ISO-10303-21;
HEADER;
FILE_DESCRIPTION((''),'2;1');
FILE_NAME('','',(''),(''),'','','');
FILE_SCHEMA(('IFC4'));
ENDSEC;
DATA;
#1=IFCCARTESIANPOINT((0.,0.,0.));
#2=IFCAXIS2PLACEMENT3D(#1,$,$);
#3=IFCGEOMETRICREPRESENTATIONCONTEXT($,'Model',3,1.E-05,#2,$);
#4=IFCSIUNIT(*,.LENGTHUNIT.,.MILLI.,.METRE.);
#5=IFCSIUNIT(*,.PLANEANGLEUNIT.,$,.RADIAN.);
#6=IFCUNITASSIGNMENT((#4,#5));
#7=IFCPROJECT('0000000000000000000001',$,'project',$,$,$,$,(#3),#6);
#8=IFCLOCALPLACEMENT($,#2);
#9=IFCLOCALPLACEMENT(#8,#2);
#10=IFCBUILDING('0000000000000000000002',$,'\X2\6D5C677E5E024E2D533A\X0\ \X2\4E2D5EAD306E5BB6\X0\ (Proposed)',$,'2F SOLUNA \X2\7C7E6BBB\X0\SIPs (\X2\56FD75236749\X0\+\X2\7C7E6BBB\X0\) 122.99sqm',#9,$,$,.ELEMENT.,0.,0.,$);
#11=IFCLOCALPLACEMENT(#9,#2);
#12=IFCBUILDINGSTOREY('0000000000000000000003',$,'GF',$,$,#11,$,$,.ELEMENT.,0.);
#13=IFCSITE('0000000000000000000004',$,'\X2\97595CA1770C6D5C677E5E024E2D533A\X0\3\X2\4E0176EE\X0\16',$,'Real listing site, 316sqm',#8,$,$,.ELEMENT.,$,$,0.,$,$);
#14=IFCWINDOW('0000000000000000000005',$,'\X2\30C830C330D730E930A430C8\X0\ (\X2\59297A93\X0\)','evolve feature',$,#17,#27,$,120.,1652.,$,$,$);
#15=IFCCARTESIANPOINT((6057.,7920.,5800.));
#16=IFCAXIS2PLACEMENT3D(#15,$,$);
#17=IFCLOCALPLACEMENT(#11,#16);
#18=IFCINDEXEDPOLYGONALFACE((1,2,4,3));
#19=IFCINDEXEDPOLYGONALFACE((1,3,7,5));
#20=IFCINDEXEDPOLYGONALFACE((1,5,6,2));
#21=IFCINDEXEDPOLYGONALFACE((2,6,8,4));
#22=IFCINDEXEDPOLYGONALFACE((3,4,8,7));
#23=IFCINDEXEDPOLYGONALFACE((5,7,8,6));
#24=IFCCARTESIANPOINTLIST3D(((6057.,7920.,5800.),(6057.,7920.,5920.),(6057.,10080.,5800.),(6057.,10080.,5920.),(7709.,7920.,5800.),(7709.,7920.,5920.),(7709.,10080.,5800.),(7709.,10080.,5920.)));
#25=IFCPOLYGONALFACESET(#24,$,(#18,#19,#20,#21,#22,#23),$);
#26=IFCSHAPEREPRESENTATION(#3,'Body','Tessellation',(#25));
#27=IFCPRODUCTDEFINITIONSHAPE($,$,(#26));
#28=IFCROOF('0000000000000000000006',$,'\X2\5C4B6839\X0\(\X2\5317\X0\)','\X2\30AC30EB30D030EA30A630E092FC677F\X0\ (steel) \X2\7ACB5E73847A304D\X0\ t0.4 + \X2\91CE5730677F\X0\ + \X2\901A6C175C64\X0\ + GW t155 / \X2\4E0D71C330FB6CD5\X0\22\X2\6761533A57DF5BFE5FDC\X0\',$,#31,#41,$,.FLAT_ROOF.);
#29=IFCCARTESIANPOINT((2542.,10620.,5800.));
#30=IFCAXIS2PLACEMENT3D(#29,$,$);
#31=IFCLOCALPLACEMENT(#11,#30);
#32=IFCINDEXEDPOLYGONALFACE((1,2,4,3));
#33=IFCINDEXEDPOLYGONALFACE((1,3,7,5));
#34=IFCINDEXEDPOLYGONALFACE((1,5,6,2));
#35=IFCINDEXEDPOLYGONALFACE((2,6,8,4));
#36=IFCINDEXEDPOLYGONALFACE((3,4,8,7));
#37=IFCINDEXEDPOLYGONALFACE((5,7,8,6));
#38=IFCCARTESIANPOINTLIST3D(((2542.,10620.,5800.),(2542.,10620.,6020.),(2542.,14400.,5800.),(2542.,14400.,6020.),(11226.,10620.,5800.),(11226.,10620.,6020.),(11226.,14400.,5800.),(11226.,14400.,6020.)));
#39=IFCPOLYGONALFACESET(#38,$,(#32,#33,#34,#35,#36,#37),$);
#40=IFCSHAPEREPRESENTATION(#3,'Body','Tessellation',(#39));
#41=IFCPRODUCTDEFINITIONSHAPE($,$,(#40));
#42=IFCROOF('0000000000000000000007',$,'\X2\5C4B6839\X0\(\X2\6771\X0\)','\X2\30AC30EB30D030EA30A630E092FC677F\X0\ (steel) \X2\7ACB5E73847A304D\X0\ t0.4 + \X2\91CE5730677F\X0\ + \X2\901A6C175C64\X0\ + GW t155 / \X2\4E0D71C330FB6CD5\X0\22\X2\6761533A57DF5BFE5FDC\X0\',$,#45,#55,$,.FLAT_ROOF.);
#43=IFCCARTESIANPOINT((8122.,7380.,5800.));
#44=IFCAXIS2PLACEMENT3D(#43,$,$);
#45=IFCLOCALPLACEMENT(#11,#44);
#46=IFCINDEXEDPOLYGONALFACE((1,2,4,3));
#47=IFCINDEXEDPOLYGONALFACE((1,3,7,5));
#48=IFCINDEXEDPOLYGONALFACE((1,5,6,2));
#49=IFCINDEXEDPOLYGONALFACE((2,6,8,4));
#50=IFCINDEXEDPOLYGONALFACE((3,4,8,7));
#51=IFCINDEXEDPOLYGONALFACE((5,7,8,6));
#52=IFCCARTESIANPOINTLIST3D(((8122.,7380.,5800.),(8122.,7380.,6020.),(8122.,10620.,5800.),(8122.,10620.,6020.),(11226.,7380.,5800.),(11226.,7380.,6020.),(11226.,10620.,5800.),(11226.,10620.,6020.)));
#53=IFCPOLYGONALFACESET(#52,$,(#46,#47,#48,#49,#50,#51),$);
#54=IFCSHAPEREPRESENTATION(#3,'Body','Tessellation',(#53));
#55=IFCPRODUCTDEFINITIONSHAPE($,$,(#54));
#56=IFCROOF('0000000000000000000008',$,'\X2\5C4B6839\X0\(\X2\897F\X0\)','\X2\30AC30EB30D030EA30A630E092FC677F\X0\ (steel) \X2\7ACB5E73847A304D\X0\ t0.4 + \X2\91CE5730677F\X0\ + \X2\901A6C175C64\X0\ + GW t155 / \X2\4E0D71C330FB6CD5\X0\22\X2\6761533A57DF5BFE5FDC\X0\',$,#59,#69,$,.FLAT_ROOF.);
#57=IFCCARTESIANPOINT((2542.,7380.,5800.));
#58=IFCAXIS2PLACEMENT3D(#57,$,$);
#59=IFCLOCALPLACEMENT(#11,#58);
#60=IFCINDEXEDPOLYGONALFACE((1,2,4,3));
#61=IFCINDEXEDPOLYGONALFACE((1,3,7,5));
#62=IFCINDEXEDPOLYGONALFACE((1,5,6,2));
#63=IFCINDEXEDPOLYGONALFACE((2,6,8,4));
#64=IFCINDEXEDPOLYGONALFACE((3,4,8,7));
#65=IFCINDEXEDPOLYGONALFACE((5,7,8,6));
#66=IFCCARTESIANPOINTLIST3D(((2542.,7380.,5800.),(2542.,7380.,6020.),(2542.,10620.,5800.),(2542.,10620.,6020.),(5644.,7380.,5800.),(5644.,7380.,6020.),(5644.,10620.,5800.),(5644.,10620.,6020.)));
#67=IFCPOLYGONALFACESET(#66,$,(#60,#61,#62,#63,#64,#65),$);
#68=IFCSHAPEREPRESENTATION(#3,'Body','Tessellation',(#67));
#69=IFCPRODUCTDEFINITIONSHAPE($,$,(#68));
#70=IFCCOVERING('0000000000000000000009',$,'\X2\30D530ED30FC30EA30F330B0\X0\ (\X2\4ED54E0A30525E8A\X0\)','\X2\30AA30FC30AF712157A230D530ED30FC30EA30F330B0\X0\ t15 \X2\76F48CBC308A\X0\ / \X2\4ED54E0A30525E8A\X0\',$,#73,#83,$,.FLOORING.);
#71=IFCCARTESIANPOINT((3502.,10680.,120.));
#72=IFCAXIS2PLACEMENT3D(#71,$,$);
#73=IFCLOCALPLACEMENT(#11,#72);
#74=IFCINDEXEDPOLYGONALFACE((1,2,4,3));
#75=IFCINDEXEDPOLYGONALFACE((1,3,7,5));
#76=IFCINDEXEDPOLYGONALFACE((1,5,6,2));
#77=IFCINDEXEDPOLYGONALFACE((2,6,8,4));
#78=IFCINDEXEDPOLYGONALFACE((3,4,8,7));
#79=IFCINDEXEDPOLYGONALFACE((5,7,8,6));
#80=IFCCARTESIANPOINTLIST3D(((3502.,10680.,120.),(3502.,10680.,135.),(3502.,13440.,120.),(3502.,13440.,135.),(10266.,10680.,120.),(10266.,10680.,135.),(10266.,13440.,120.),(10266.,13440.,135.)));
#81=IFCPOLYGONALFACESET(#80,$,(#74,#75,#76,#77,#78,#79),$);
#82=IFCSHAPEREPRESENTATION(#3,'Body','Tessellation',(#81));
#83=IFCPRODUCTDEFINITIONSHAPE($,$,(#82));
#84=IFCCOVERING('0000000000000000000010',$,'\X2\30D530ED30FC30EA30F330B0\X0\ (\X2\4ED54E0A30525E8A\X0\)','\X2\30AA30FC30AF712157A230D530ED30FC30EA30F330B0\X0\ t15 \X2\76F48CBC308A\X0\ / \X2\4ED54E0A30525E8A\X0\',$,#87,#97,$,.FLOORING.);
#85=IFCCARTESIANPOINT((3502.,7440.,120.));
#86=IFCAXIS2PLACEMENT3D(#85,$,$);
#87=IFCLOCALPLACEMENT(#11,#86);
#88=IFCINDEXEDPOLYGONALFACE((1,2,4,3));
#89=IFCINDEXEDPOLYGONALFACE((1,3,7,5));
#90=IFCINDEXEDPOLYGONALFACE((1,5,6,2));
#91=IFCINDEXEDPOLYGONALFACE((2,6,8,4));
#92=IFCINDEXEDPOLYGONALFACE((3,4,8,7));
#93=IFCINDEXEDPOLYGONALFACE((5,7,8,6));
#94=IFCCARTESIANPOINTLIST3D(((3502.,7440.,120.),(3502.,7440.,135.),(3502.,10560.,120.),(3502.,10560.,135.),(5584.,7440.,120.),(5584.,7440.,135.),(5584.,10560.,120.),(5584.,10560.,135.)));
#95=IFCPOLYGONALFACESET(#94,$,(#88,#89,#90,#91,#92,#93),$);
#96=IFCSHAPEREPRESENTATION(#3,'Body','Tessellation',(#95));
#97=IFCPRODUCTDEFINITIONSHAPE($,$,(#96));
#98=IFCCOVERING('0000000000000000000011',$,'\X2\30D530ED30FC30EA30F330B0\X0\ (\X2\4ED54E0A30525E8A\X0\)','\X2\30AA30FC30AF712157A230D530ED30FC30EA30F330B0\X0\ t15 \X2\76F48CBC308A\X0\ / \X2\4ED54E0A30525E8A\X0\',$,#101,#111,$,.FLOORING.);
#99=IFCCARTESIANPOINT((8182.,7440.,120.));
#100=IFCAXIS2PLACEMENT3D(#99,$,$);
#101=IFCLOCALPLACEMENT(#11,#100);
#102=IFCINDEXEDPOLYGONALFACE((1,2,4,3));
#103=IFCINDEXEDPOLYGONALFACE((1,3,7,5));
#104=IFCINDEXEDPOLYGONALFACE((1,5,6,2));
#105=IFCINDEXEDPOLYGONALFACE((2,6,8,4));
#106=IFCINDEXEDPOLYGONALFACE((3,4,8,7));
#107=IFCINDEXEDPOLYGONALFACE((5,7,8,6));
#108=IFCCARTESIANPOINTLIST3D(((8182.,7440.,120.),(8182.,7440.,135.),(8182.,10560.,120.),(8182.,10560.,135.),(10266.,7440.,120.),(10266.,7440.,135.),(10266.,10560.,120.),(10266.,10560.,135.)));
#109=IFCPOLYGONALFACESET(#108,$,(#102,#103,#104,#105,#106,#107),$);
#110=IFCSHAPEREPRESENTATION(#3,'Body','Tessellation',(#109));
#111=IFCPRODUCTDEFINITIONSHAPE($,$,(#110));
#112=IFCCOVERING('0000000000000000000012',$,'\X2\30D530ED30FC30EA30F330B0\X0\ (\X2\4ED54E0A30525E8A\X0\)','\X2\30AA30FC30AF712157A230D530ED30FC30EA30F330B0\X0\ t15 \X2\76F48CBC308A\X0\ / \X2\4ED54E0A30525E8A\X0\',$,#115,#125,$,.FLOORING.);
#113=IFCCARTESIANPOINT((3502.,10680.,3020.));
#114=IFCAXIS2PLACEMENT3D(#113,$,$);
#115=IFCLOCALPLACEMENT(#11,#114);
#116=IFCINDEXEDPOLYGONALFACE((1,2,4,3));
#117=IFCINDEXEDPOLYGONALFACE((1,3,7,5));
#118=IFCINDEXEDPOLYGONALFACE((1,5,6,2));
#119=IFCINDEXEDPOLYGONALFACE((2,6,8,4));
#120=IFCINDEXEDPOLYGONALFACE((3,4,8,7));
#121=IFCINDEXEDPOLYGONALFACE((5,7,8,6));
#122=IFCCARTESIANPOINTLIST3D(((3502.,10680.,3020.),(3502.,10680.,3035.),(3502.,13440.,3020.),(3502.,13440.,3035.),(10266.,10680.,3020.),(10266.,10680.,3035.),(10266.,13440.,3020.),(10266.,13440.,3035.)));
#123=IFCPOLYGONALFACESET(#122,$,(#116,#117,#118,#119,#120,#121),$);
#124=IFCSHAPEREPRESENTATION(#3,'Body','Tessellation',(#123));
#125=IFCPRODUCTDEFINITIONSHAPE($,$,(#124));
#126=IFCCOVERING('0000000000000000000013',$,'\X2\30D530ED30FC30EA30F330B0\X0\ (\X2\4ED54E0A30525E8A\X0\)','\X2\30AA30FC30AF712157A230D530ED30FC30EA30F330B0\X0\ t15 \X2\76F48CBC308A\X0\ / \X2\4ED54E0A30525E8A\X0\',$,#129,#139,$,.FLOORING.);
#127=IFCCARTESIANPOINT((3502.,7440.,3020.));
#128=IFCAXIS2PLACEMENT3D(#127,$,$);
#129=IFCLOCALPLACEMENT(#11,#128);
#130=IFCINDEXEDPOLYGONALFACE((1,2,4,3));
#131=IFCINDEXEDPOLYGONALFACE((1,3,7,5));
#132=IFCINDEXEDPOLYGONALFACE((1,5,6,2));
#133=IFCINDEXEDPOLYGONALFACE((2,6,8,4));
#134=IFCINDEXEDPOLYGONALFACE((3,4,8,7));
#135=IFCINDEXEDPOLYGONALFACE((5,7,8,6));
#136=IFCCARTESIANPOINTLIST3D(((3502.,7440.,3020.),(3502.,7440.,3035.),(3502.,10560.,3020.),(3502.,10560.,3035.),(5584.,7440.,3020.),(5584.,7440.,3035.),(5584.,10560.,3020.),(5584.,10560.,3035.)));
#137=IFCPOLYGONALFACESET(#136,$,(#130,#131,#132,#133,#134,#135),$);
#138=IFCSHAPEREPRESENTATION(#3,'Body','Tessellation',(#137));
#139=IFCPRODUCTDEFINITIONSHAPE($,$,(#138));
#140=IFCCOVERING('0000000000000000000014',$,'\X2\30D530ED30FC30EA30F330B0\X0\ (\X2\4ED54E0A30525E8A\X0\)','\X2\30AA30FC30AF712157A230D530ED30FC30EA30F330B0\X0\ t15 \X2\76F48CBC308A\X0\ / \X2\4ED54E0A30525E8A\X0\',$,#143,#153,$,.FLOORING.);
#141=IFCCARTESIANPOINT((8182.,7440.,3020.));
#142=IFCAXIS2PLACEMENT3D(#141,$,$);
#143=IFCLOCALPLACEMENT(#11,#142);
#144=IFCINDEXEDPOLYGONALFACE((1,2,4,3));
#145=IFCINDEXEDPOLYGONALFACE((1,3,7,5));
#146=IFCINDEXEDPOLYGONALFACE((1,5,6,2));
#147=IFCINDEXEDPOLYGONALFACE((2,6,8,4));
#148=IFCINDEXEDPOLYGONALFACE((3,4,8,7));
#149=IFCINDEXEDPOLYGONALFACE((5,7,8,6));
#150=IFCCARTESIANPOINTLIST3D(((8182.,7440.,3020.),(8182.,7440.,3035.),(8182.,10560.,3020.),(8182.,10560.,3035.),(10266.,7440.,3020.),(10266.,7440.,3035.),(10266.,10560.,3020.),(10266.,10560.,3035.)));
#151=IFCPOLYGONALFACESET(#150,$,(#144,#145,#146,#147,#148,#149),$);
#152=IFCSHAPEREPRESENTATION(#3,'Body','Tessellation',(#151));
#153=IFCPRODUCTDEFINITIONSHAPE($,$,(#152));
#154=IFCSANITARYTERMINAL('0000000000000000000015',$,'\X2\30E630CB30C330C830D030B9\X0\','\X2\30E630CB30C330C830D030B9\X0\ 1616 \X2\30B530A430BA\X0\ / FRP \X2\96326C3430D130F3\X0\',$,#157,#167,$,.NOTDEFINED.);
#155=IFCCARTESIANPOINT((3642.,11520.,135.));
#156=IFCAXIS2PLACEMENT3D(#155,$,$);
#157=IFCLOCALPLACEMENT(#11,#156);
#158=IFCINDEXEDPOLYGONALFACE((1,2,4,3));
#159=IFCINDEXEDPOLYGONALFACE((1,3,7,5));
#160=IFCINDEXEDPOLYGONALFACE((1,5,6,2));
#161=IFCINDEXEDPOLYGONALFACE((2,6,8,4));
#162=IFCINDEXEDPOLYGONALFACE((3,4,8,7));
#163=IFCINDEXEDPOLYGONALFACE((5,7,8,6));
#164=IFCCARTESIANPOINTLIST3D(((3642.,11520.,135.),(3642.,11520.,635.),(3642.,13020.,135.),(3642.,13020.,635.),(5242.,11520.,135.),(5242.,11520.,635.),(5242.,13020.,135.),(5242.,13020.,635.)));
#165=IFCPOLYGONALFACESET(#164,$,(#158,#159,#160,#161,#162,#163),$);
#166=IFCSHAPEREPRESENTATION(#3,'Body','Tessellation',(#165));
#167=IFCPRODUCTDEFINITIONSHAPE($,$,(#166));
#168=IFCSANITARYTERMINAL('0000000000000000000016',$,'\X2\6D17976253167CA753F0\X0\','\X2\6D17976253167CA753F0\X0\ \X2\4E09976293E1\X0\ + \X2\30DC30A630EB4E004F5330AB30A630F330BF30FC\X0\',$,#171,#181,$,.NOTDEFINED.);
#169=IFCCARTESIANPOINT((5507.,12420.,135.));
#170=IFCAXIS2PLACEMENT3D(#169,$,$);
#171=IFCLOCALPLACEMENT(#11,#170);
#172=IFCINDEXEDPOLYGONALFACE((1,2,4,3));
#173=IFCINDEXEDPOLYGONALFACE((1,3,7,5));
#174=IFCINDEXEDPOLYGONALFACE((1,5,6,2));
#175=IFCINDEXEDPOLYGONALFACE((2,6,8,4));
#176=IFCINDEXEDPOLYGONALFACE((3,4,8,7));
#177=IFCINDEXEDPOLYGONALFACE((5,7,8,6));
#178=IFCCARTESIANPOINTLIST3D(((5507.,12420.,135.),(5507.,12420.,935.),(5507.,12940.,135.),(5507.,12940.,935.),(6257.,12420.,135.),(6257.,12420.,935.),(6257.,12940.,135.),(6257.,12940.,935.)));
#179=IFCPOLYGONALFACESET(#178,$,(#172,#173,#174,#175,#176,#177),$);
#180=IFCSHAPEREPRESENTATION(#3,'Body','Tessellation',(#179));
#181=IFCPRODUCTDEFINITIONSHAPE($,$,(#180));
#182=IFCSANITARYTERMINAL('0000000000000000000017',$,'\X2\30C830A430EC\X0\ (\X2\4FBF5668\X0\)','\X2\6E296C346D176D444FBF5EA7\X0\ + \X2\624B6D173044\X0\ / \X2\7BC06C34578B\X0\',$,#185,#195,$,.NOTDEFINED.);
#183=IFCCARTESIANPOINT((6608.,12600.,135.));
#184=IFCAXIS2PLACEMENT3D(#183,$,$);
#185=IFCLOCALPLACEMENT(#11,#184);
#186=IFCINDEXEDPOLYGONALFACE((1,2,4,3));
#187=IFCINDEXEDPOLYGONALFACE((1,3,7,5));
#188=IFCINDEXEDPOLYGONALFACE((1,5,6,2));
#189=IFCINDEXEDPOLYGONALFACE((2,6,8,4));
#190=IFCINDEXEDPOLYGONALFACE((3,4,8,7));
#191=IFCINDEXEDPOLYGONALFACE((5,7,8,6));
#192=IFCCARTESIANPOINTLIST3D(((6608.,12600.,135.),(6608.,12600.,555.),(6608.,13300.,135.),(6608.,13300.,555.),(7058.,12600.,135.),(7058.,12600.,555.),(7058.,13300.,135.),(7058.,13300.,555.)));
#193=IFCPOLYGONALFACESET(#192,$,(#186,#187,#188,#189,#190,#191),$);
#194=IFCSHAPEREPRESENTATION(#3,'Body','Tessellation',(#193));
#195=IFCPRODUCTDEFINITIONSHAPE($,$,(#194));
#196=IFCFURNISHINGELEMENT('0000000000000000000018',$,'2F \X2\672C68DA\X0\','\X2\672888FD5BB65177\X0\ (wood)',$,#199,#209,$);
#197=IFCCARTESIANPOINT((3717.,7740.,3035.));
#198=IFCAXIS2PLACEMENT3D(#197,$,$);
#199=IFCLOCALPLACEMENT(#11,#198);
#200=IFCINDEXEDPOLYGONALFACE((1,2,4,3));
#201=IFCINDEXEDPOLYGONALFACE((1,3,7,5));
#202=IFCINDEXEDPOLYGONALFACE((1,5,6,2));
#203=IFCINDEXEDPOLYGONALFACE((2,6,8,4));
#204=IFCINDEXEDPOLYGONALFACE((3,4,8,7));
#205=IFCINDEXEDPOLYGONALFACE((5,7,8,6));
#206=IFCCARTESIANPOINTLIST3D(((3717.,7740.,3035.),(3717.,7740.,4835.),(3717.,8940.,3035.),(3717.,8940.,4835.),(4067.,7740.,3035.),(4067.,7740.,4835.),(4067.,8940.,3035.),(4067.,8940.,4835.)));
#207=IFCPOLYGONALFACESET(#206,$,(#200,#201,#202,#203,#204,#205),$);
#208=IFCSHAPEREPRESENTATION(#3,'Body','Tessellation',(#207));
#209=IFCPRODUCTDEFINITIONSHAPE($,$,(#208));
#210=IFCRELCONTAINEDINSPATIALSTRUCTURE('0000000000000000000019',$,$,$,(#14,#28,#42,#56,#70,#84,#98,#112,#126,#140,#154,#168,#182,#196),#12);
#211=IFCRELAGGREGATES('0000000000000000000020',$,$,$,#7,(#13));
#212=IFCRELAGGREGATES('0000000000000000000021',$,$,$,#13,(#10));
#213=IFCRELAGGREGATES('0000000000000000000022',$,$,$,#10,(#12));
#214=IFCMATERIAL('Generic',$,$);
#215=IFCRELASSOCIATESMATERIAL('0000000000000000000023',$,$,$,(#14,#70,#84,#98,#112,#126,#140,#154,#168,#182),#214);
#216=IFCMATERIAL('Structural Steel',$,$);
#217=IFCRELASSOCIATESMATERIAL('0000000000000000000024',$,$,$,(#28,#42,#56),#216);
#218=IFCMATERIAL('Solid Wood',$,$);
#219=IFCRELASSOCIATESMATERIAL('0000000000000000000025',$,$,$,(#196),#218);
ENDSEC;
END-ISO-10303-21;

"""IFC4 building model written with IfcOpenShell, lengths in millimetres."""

from ifc_helpers import new_model, si_unit, frame, frame_2d, origin, place, context, project, spatial, rectangle, extrude, material, element, save


model = new_model("IFC4")

# Units and contexts
model_context = context("Model", 3, precision=1e-05, world=origin())
ifc_project = project(units=[si_unit("LENGTHUNIT", "METRE", prefix="MILLI"), si_unit("PLANEANGLEUNIT", "RADIAN")], contexts=[model_context])

# Site, building, storey
site_placement = place(None, origin())
site = spatial("IfcSite", under=ifc_project, at=site_placement, Name="静岡県浜松市中区3丁目16", ObjectType="Real listing site, 316sqm", CompositionType="ELEMENT", RefElevation=0.0)
building_placement = place(site_placement, origin())
building = spatial("IfcBuilding", under=site, at=building_placement, Name="浜松市中区 中庭の家 (Proposed)", ObjectType="2F SOLUNA 籾殻SIPs (国産杉+籾殻) 122.99sqm", CompositionType="ELEMENT", ElevationOfRefHeight=0.0, ElevationOfTerrain=0.0)
storey_placement = place(building_placement, origin())
storey = spatial("IfcBuildingStorey", under=building, at=storey_placement, Name="GF", CompositionType="ELEMENT", Elevation=0.0)

# Shared definitions
ifc_material_1 = material(Name="Solid Wood")

# Window
ifc_material_2 = material(Name="Generic")
window_1_placement = place(storey_placement, frame((6057.0, 7920.0, 5800.0)))
element("IfcWindow", 1, at=window_1_placement, inside=storey, material=ifc_material_2, Name="トップライト (天窓)", Description="evolve feature", OverallHeight=120.0, OverallWidth=1652.0, context=model_context, shape_type="SweptSolid", body=[
    extrude(rectangle(XDim=1652.0, YDim=2160.0, at=frame_2d((826.0, 1080.0))), frame((6057.0, 7920.0, 5800.0)), (0.0, 0.0, 1.0), 120.0),
])

# Roofs
ifc_material_3 = material(Name="Structural Steel")
roof_1_placement = place(storey_placement, frame((2542.0, 10620.0, 5800.0)))
element("IfcRoof", 2, at=roof_1_placement, inside=storey, material=ifc_material_3, Name="屋根(北)", Description="ガルバリウム鋼板 (steel) 立平葺き t0.4 + 野地板 + 通気層 + GW t155 / 不燃・法22条区域対応", PredefinedType="FLAT_ROOF", context=model_context, shape_type="SweptSolid", body=[
    extrude(rectangle(XDim=8684.0, YDim=3780.0, at=frame_2d((4342.0, 1890.0))), frame((2542.0, 10620.0, 5800.0)), (0.0, 0.0, 1.0), 220.0),
])
roof_2_placement = place(storey_placement, frame((8122.0, 7380.0, 5800.0)))
element("IfcRoof", 3, at=roof_2_placement, inside=storey, material=ifc_material_3, Name="屋根(東)", Description="ガルバリウム鋼板 (steel) 立平葺き t0.4 + 野地板 + 通気層 + GW t155 / 不燃・法22条区域対応", PredefinedType="FLAT_ROOF", context=model_context, shape_type="SweptSolid", body=[
    extrude(rectangle(XDim=3104.0, YDim=3240.0, at=frame_2d((1552.0, 1620.0))), frame((8122.0, 7380.0, 5800.0)), (0.0, 0.0, 1.0), 220.0),
])
roof_3_placement = place(storey_placement, frame((2542.0, 7380.0, 5800.0)))
element("IfcRoof", 4, at=roof_3_placement, inside=storey, material=ifc_material_3, Name="屋根(西)", Description="ガルバリウム鋼板 (steel) 立平葺き t0.4 + 野地板 + 通気層 + GW t155 / 不燃・法22条区域対応", PredefinedType="FLAT_ROOF", context=model_context, shape_type="SweptSolid", body=[
    extrude(rectangle(XDim=3102.0, YDim=3240.0, at=frame_2d((1551.0, 1620.0))), frame((2542.0, 7380.0, 5800.0)), (0.0, 0.0, 1.0), 220.0),
])

# Coverings
covering_1_placement = place(storey_placement, frame((3502.0, 10680.0, 120.0)))
element("IfcCovering", 5, at=covering_1_placement, inside=storey, material=ifc_material_2, Name="フローリング (仕上げ床)", Description="オーク無垢フローリング t15 直貼り / 仕上げ床", PredefinedType="FLOORING", context=model_context, shape_type="SweptSolid", body=[
    extrude(rectangle(XDim=6764.0, YDim=2760.0, at=frame_2d((3382.0, 1380.0))), frame((3502.0, 10680.0, 120.0)), (0.0, 0.0, 1.0), 15.0),
])
covering_2_placement = place(storey_placement, frame((3502.0, 7440.0, 120.0)))
element("IfcCovering", 6, at=covering_2_placement, inside=storey, material=ifc_material_2, Name="フローリング (仕上げ床)", Description="オーク無垢フローリング t15 直貼り / 仕上げ床", PredefinedType="FLOORING", context=model_context, shape_type="SweptSolid", body=[
    extrude(rectangle(XDim=2082.0, YDim=3120.0, at=frame_2d((1041.0, 1560.0))), frame((3502.0, 7440.0, 120.0)), (0.0, 0.0, 1.0), 15.0),
])
covering_3_placement = place(storey_placement, frame((8182.0, 7440.0, 120.0)))
element("IfcCovering", 7, at=covering_3_placement, inside=storey, material=ifc_material_2, Name="フローリング (仕上げ床)", Description="オーク無垢フローリング t15 直貼り / 仕上げ床", PredefinedType="FLOORING", context=model_context, shape_type="SweptSolid", body=[
    extrude(rectangle(XDim=2084.0, YDim=3120.0, at=frame_2d((1042.0, 1560.0))), frame((8182.0, 7440.0, 120.0)), (0.0, 0.0, 1.0), 15.0),
])
covering_4_placement = place(storey_placement, frame((3502.0, 10680.0, 3020.0)))
element("IfcCovering", 8, at=covering_4_placement, inside=storey, material=ifc_material_2, Name="フローリング (仕上げ床)", Description="オーク無垢フローリング t15 直貼り / 仕上げ床", PredefinedType="FLOORING", context=model_context, shape_type="SweptSolid", body=[
    extrude(rectangle(XDim=6764.0, YDim=2760.0, at=frame_2d((3382.0, 1380.0))), frame((3502.0, 10680.0, 3020.0)), (0.0, 0.0, 1.0), 15.0),
])
covering_5_placement = place(storey_placement, frame((3502.0, 7440.0, 3020.0)))
element("IfcCovering", 9, at=covering_5_placement, inside=storey, material=ifc_material_2, Name="フローリング (仕上げ床)", Description="オーク無垢フローリング t15 直貼り / 仕上げ床", PredefinedType="FLOORING", context=model_context, shape_type="SweptSolid", body=[
    extrude(rectangle(XDim=2082.0, YDim=3120.0, at=frame_2d((1041.0, 1560.0))), frame((3502.0, 7440.0, 3020.0)), (0.0, 0.0, 1.0), 15.0),
])
covering_6_placement = place(storey_placement, frame((8182.0, 7440.0, 3020.0)))
element("IfcCovering", 10, at=covering_6_placement, inside=storey, material=ifc_material_2, Name="フローリング (仕上げ床)", Description="オーク無垢フローリング t15 直貼り / 仕上げ床", PredefinedType="FLOORING", context=model_context, shape_type="SweptSolid", body=[
    extrude(rectangle(XDim=2084.0, YDim=3120.0, at=frame_2d((1042.0, 1560.0))), frame((8182.0, 7440.0, 3020.0)), (0.0, 0.0, 1.0), 15.0),
])

# Sanitary terminals
sanitary_terminal_1_placement = place(storey_placement, frame((3642.0, 11520.0, 135.0)))
element("IfcSanitaryTerminal", 11, at=sanitary_terminal_1_placement, inside=storey, material=ifc_material_2, Name="ユニットバス", Description="ユニットバス 1616 サイズ / FRP 防水パン", PredefinedType="NOTDEFINED", context=model_context, shape_type="SweptSolid", body=[
    extrude(rectangle(XDim=1600.0, YDim=1500.0, at=frame_2d((800.0, 750.0))), frame((3642.0, 11520.0, 135.0)), (0.0, 0.0, 1.0), 500.0),
])
sanitary_terminal_2_placement = place(storey_placement, frame((5507.0, 12420.0, 135.0)))
element("IfcSanitaryTerminal", 12, at=sanitary_terminal_2_placement, inside=storey, material=ifc_material_2, Name="洗面化粧台", Description="洗面化粧台 三面鏡 + ボウル一体カウンター", PredefinedType="NOTDEFINED", context=model_context, shape_type="SweptSolid", body=[
    extrude(rectangle(XDim=750.0, YDim=520.0, at=frame_2d((375.0, 260.0))), frame((5507.0, 12420.0, 135.0)), (0.0, 0.0, 1.0), 800.0),
])
sanitary_terminal_3_placement = place(storey_placement, frame((6608.0, 12600.0, 135.0)))
element("IfcSanitaryTerminal", 13, at=sanitary_terminal_3_placement, inside=storey, material=ifc_material_2, Name="トイレ (便器)", Description="温水洗浄便座 + 手洗い / 節水型", PredefinedType="NOTDEFINED", context=model_context, shape_type="SweptSolid", body=[
    extrude(rectangle(XDim=450.0, YDim=700.0, at=frame_2d((225.0, 350.0))), frame((6608.0, 12600.0, 135.0)), (0.0, 0.0, 1.0), 420.0),
])

# Furnishing element
furnishing_placement = place(storey_placement, frame((3717.0, 7740.0, 3035.0)))
element("IfcFurnishingElement", 14, at=furnishing_placement, inside=storey, material=ifc_material_1, Name="2F 本棚", Description="木製家具 (wood)", context=model_context, shape_type="SweptSolid", body=[
    extrude(rectangle(XDim=350.0, YDim=1200.0, at=frame_2d((175.0, 600.0))), frame((3717.0, 7740.0, 3035.0)), (0.0, 0.0, 1.0), 1800.0),
])

save(model, "model.ifc")
